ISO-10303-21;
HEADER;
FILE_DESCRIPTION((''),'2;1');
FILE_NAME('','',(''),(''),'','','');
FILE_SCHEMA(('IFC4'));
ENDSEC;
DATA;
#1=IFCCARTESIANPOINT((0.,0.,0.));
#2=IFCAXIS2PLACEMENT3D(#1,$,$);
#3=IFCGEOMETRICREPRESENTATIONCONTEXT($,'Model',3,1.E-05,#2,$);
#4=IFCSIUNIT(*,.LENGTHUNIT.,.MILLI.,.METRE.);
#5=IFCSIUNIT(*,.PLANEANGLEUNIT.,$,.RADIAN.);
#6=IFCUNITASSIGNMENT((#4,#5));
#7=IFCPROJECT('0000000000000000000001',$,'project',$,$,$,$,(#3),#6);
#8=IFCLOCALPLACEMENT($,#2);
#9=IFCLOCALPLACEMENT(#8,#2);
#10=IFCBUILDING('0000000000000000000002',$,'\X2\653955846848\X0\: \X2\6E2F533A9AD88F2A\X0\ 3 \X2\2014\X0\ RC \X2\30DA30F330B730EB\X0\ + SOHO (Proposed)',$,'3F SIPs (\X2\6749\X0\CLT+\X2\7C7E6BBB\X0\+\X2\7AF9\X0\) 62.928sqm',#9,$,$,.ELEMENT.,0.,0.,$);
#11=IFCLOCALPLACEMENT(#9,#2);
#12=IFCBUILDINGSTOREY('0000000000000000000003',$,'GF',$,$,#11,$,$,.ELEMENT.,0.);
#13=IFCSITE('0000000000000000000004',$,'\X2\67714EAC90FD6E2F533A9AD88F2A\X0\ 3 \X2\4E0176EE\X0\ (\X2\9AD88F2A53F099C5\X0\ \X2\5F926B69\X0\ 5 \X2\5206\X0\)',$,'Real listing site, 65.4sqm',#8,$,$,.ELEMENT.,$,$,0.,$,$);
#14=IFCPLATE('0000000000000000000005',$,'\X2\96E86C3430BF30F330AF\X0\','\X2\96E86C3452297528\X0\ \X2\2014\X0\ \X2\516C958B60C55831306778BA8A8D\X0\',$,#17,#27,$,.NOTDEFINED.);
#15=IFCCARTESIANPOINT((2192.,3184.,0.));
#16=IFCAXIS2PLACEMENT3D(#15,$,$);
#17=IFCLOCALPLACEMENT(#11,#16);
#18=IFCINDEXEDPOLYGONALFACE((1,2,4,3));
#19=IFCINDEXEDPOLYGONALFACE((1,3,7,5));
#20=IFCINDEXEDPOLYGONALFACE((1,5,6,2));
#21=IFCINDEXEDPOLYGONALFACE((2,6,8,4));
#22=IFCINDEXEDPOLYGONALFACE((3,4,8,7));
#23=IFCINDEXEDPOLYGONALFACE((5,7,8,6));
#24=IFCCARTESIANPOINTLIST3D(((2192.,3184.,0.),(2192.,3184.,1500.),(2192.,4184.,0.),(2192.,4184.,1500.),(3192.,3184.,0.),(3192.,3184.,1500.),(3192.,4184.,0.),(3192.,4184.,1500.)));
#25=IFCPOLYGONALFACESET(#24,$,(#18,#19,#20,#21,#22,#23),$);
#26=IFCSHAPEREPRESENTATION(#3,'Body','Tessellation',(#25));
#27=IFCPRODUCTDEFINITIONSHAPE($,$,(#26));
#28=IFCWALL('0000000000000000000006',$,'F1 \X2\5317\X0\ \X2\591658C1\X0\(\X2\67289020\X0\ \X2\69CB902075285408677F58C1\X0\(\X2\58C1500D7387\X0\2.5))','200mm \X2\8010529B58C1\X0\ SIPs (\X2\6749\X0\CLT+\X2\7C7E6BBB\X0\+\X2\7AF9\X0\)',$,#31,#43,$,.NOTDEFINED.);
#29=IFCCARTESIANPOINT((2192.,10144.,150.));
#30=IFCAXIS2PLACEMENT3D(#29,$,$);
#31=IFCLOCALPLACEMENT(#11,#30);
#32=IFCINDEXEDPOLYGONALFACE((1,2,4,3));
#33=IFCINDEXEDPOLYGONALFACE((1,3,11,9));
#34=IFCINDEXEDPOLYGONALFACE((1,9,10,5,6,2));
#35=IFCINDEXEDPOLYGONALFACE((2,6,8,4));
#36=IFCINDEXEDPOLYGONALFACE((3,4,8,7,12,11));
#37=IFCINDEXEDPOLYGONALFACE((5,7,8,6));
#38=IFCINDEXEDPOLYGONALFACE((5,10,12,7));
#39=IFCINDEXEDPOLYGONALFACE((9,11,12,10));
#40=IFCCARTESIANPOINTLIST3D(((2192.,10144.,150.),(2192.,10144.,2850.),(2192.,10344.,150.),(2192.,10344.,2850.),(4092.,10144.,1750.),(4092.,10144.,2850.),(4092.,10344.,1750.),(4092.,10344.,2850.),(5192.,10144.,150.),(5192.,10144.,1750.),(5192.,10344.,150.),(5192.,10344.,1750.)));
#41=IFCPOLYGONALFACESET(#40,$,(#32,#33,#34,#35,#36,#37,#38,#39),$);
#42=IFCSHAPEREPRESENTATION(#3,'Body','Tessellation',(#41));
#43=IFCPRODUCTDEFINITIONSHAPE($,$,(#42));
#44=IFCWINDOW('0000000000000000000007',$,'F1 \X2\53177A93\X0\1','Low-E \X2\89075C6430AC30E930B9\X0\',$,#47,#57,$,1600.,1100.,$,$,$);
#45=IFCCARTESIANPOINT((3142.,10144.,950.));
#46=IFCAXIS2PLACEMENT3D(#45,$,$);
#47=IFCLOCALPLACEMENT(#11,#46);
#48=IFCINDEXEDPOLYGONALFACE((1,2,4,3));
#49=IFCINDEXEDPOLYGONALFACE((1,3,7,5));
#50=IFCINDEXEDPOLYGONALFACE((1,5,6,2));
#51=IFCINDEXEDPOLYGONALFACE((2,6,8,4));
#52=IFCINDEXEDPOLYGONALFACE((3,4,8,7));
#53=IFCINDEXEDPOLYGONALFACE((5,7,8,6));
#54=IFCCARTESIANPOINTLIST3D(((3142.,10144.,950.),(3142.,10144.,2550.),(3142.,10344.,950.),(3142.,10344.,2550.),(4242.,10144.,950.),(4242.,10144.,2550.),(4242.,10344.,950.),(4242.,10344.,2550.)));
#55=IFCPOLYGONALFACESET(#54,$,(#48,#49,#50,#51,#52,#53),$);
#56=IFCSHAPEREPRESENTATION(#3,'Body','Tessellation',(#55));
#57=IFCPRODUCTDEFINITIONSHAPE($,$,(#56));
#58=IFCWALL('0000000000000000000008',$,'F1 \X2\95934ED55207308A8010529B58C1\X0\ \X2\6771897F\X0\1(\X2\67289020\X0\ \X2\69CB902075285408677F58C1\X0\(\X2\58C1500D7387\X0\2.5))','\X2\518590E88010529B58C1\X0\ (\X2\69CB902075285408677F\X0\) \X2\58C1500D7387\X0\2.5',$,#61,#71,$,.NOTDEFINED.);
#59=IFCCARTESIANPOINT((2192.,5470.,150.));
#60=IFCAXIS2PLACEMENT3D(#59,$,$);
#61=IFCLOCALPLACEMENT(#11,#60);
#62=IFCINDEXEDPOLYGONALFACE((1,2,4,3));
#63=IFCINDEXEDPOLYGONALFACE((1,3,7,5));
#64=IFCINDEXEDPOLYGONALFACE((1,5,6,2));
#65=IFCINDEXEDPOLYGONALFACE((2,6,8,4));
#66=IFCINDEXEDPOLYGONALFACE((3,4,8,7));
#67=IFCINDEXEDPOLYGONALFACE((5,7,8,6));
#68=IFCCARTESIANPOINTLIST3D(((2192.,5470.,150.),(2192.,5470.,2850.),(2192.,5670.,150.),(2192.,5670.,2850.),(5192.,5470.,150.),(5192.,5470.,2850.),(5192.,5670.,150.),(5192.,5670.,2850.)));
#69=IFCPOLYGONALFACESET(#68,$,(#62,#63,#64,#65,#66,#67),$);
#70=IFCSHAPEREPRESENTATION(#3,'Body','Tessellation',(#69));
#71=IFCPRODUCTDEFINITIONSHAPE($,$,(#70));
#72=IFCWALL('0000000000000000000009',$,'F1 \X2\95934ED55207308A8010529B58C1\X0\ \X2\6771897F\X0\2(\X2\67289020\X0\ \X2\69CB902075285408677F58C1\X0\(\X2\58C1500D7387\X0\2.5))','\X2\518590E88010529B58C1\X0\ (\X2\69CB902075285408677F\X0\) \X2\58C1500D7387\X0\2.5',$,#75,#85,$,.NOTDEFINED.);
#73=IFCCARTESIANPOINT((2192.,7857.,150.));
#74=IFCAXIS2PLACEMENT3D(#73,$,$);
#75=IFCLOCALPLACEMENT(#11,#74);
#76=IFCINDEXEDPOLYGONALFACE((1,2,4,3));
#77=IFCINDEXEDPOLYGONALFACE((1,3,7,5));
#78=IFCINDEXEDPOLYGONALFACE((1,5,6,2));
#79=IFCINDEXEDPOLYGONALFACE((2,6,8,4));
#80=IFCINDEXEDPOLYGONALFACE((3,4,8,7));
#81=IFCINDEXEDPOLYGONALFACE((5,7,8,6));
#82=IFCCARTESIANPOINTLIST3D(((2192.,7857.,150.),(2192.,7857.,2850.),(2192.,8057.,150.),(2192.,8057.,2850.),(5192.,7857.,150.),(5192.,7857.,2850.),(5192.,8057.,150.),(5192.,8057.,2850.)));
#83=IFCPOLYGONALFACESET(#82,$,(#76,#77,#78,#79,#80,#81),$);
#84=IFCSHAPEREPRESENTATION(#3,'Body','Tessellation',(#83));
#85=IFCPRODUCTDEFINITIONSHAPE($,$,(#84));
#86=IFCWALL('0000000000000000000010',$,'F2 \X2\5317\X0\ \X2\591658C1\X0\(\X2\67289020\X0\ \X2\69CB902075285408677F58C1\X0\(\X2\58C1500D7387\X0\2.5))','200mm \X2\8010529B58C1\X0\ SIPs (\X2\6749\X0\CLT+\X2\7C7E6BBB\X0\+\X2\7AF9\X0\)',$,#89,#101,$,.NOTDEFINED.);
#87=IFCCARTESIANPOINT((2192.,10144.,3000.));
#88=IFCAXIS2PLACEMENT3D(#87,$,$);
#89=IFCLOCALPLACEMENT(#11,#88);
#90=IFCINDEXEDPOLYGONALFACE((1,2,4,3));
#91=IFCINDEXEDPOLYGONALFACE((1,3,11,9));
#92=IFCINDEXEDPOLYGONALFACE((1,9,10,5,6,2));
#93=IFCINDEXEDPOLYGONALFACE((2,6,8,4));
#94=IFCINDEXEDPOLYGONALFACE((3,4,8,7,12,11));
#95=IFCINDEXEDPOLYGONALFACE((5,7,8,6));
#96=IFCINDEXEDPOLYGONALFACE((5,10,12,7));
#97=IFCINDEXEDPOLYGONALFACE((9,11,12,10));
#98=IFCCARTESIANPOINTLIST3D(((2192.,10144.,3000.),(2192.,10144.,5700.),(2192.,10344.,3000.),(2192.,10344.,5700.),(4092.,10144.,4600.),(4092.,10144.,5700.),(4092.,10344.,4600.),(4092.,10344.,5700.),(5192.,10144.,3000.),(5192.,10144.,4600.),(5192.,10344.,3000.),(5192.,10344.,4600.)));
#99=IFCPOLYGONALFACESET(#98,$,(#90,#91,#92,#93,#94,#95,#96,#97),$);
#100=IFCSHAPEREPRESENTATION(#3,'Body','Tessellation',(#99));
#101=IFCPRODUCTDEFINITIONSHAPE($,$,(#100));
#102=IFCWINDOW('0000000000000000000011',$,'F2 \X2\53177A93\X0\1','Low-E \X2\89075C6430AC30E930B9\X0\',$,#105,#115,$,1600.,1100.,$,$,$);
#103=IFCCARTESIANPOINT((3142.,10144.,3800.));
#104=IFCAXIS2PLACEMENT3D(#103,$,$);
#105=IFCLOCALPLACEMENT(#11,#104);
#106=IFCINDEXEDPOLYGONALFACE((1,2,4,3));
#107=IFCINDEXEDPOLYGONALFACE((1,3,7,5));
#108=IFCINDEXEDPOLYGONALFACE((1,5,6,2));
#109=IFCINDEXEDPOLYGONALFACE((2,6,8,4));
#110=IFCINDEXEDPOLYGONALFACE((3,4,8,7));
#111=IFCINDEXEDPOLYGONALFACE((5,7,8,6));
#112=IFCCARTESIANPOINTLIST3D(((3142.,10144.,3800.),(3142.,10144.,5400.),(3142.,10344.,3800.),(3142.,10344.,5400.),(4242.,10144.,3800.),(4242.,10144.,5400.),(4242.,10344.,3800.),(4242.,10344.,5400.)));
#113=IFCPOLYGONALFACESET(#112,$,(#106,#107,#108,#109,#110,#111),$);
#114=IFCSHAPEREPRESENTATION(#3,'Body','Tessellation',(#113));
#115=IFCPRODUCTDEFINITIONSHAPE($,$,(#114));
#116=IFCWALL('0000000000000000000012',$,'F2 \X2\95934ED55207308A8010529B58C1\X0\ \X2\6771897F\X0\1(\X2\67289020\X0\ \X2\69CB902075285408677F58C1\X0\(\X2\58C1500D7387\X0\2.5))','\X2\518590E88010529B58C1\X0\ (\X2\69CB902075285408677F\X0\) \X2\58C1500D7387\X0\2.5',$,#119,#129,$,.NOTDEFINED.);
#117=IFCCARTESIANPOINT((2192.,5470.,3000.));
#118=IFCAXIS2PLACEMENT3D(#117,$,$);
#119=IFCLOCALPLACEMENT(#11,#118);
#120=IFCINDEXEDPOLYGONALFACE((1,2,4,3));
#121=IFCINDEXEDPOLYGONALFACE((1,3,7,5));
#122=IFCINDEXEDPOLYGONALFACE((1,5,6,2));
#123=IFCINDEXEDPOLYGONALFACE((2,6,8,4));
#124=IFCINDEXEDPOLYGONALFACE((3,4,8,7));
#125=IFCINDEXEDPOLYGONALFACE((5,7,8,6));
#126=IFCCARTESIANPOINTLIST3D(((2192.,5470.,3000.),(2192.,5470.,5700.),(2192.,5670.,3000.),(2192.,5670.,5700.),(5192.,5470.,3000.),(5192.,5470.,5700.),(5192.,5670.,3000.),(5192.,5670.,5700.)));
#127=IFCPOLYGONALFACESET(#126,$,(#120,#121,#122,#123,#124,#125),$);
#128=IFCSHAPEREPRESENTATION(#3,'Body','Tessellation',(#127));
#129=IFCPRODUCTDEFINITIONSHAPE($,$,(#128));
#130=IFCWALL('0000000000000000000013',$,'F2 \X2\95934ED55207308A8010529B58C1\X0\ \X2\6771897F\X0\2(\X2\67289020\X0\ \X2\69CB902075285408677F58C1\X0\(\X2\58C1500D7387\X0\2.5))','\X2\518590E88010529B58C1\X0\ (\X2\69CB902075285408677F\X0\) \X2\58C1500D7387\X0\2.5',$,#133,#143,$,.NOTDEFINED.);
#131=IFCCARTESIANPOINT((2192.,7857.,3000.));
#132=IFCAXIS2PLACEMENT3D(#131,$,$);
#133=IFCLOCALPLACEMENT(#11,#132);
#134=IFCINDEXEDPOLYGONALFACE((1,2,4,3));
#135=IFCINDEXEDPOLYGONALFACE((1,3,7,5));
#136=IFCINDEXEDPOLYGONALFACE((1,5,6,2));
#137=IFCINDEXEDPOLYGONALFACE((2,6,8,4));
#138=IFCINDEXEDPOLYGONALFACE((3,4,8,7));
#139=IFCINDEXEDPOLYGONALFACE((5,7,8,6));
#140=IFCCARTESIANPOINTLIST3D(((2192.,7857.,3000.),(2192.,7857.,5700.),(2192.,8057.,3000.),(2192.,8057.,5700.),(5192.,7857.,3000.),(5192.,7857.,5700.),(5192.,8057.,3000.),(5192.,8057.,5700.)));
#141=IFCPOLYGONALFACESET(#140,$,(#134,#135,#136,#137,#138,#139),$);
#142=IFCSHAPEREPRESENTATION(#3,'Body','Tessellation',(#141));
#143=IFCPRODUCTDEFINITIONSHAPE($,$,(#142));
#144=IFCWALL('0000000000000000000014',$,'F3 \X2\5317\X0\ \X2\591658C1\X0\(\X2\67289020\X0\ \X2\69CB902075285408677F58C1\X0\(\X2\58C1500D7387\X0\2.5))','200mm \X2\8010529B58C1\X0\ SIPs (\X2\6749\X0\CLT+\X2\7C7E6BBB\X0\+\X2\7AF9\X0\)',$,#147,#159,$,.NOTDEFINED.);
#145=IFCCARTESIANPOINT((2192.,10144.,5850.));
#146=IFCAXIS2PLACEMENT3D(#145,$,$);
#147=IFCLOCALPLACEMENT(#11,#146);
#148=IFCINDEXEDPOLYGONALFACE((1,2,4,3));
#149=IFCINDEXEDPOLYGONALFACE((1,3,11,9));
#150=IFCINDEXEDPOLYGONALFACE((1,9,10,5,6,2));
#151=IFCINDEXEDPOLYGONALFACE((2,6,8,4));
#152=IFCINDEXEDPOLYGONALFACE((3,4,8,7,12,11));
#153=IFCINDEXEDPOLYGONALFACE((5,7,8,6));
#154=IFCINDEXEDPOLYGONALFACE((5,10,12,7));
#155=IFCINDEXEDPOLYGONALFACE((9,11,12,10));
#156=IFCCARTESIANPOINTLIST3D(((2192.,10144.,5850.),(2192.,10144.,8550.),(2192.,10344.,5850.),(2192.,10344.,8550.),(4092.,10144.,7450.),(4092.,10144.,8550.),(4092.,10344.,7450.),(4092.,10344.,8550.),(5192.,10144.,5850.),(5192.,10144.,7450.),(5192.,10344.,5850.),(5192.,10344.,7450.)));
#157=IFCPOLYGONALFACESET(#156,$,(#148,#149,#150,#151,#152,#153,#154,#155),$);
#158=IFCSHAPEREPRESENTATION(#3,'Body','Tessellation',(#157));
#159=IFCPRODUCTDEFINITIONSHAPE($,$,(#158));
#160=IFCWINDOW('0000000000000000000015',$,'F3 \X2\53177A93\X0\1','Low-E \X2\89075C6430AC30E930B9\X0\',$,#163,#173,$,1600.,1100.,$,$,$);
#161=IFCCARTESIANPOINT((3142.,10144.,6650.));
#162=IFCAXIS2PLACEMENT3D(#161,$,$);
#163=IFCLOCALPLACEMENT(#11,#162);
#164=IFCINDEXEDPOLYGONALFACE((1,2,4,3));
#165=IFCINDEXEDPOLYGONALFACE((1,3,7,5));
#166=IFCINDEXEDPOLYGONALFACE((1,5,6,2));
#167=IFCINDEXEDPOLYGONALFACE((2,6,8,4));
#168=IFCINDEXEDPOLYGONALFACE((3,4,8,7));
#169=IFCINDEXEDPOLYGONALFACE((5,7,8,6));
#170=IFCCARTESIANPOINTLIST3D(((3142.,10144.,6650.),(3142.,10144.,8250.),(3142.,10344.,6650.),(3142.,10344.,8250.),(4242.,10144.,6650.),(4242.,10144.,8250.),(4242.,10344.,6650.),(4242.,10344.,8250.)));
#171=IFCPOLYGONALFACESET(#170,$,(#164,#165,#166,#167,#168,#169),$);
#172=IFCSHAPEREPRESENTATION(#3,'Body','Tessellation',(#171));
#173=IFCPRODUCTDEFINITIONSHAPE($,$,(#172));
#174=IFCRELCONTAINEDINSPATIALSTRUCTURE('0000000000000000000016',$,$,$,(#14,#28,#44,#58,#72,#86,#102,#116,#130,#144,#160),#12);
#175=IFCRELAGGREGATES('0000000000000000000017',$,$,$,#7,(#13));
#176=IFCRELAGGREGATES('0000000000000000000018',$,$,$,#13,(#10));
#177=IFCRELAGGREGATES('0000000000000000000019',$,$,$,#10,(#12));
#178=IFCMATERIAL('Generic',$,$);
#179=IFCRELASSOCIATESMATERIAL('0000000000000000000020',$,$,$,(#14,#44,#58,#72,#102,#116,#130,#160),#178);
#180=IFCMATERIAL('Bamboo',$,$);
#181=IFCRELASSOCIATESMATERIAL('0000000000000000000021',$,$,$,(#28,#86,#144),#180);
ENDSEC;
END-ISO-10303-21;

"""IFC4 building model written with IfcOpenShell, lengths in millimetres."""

from ifc_helpers import new_model, si_unit, frame, frame_2d, origin, place, context, project, spatial, rectangle, extrude, material, element, fill, save


model = new_model("IFC4")

# Units and contexts
model_context = context("Model", 3, precision=1e-05, world=origin())
ifc_project = project(units=[si_unit("LENGTHUNIT", "METRE", prefix="MILLI"), si_unit("PLANEANGLEUNIT", "RADIAN")], contexts=[model_context])

# Site, building, storey
site_placement = place(None, origin())
site = spatial("IfcSite", under=ifc_project, at=site_placement, Name="東京都港区高輪 3 丁目 (高輪台駅 徒歩 5 分)", ObjectType="Real listing site, 65.4sqm", CompositionType="ELEMENT", RefElevation=0.0)
building_placement = place(site_placement, origin())
building = spatial("IfcBuilding", under=site, at=building_placement, Name="改善案: 港区高輪 3 — RC ペンシル + SOHO (Proposed)", ObjectType="3F SIPs (杉CLT+籾殻+竹) 62.928sqm", CompositionType="ELEMENT", ElevationOfRefHeight=0.0, ElevationOfTerrain=0.0)
storey_placement = place(building_placement, origin())
storey = spatial("IfcBuildingStorey", under=building, at=storey_placement, Name="GF", CompositionType="ELEMENT", Elevation=0.0)

# Plate
ifc_material_1 = material(Name="Generic")
plate_placement = place(storey_placement, frame((2192.0, 3184.0, 0.0)))
element("IfcPlate", 1, at=plate_placement, inside=storey, material=ifc_material_1, Name="雨水タンク", Description="雨水利用 — 公開情報で確認", PredefinedType="NOTDEFINED", context=model_context, shape_type="SweptSolid", body=[
    extrude(rectangle(XDim=1000.0, YDim=1000.0, at=frame_2d((500.0, 500.0))), frame((2192.0, 3184.0, 0.0)), (0.0, 0.0, 1.0), 1500.0),
])

# Wall, opening, window
ifc_material_2 = material(Name="Bamboo")
wall_1_placement = place(storey_placement, frame((2192.0, 10144.0, 150.0)))
wall_1 = element("IfcWall", 2, at=wall_1_placement, inside=storey, material=ifc_material_2, Name="F1 北 外壁(木造 構造用合板壁(壁倍率2.5))", Description="200mm 耐力壁 SIPs (杉CLT+籾殻+竹)", PredefinedType="NOTDEFINED", context=model_context, shape_type="SweptSolid", body=[
    extrude(rectangle(XDim=3000.0, YDim=200.0, at=frame_2d((1500.0, 100.0))), frame((2192.0, 10144.0, 150.0)), (0.0, 0.0, 1.0), 2700.0),
])
opening_1_placement = place(storey_placement, frame((3142.0, 10144.0, 950.0)))
opening_1 = element("IfcOpeningElement", 3, at=opening_1_placement, cuts=wall_1, PredefinedType="NOTDEFINED", context=model_context, shape_type="SweptSolid", body=[
    extrude(rectangle(XDim=1100.0, YDim=200.0, at=frame_2d((550.0, 100.0))), frame((3142.0, 10144.0, 950.0)), (0.0, 0.0, 1.0), 1600.0),
])
window_1_placement = place(storey_placement, frame((3142.0, 10144.0, 950.0)))
window_1 = element("IfcWindow", 4, at=window_1_placement, inside=storey, material=ifc_material_1, Name="F1 北窓1", Description="Low-E 複層ガラス", OverallHeight=1600.0, OverallWidth=1100.0, context=model_context, shape_type="SweptSolid", body=[
    extrude(rectangle(XDim=1100.0, YDim=200.0, at=frame_2d((550.0, 100.0))), frame((3142.0, 10144.0, 950.0)), (0.0, 0.0, 1.0), 1600.0),
])
fill(opening_1, window_1)

# Walls
wall_2_placement = place(storey_placement, frame((2192.0, 5470.0, 150.0)))
element("IfcWall", 5, at=wall_2_placement, inside=storey, material=ifc_material_1, Name="F1 間仕切り耐力壁 東西1(木造 構造用合板壁(壁倍率2.5))", Description="内部耐力壁 (構造用合板) 壁倍率2.5", PredefinedType="NOTDEFINED", context=model_context, shape_type="SweptSolid", body=[
    extrude(rectangle(XDim=3000.0, YDim=200.0, at=frame_2d((1500.0, 100.0))), frame((2192.0, 5470.0, 150.0)), (0.0, 0.0, 1.0), 2700.0),
])
wall_3_placement = place(storey_placement, frame((2192.0, 7857.0, 150.0)))
element("IfcWall", 6, at=wall_3_placement, inside=storey, material=ifc_material_1, Name="F1 間仕切り耐力壁 東西2(木造 構造用合板壁(壁倍率2.5))", Description="内部耐力壁 (構造用合板) 壁倍率2.5", PredefinedType="NOTDEFINED", context=model_context, shape_type="SweptSolid", body=[
    extrude(rectangle(XDim=3000.0, YDim=200.0, at=frame_2d((1500.0, 100.0))), frame((2192.0, 7857.0, 150.0)), (0.0, 0.0, 1.0), 2700.0),
])

# Wall, opening, window
wall_4_placement = place(storey_placement, frame((2192.0, 10144.0, 3000.0)))
wall_4 = element("IfcWall", 7, at=wall_4_placement, inside=storey, material=ifc_material_2, Name="F2 北 外壁(木造 構造用合板壁(壁倍率2.5))", Description="200mm 耐力壁 SIPs (杉CLT+籾殻+竹)", PredefinedType="NOTDEFINED", context=model_context, shape_type="SweptSolid", body=[
    extrude(rectangle(XDim=3000.0, YDim=200.0, at=frame_2d((1500.0, 100.0))), frame((2192.0, 10144.0, 3000.0)), (0.0, 0.0, 1.0), 2700.0),
])
opening_2_placement = place(storey_placement, frame((3142.0, 10144.0, 3800.0)))
opening_2 = element("IfcOpeningElement", 8, at=opening_2_placement, cuts=wall_4, PredefinedType="NOTDEFINED", context=model_context, shape_type="SweptSolid", body=[
    extrude(rectangle(XDim=1100.0, YDim=200.0, at=frame_2d((550.0, 100.0))), frame((3142.0, 10144.0, 3800.0)), (0.0, 0.0, 1.0), 1600.0),
])
window_2_placement = place(storey_placement, frame((3142.0, 10144.0, 3800.0)))
window_2 = element("IfcWindow", 9, at=window_2_placement, inside=storey, material=ifc_material_1, Name="F2 北窓1", Description="Low-E 複層ガラス", OverallHeight=1600.0, OverallWidth=1100.0, context=model_context, shape_type="SweptSolid", body=[
    extrude(rectangle(XDim=1100.0, YDim=200.0, at=frame_2d((550.0, 100.0))), frame((3142.0, 10144.0, 3800.0)), (0.0, 0.0, 1.0), 1600.0),
])
fill(opening_2, window_2)

# Walls
wall_5_placement = place(storey_placement, frame((2192.0, 5470.0, 3000.0)))
element("IfcWall", 10, at=wall_5_placement, inside=storey, material=ifc_material_1, Name="F2 間仕切り耐力壁 東西1(木造 構造用合板壁(壁倍率2.5))", Description="内部耐力壁 (構造用合板) 壁倍率2.5", PredefinedType="NOTDEFINED", context=model_context, shape_type="SweptSolid", body=[
    extrude(rectangle(XDim=3000.0, YDim=200.0, at=frame_2d((1500.0, 100.0))), frame((2192.0, 5470.0, 3000.0)), (0.0, 0.0, 1.0), 2700.0),
])
wall_6_placement = place(storey_placement, frame((2192.0, 7857.0, 3000.0)))
element("IfcWall", 11, at=wall_6_placement, inside=storey, material=ifc_material_1, Name="F2 間仕切り耐力壁 東西2(木造 構造用合板壁(壁倍率2.5))", Description="内部耐力壁 (構造用合板) 壁倍率2.5", PredefinedType="NOTDEFINED", context=model_context, shape_type="SweptSolid", body=[
    extrude(rectangle(XDim=3000.0, YDim=200.0, at=frame_2d((1500.0, 100.0))), frame((2192.0, 7857.0, 3000.0)), (0.0, 0.0, 1.0), 2700.0),
])

# Wall, opening, window
wall_7_placement = place(storey_placement, frame((2192.0, 10144.0, 5850.0)))
wall_7 = element("IfcWall", 12, at=wall_7_placement, inside=storey, material=ifc_material_2, Name="F3 北 外壁(木造 構造用合板壁(壁倍率2.5))", Description="200mm 耐力壁 SIPs (杉CLT+籾殻+竹)", PredefinedType="NOTDEFINED", context=model_context, shape_type="SweptSolid", body=[
    extrude(rectangle(XDim=3000.0, YDim=200.0, at=frame_2d((1500.0, 100.0))), frame((2192.0, 10144.0, 5850.0)), (0.0, 0.0, 1.0), 2700.0),
])
opening_3_placement = place(storey_placement, frame((3142.0, 10144.0, 6650.0)))
opening_3 = element("IfcOpeningElement", 13, at=opening_3_placement, cuts=wall_7, PredefinedType="NOTDEFINED", context=model_context, shape_type="SweptSolid", body=[
    extrude(rectangle(XDim=1100.0, YDim=200.0, at=frame_2d((550.0, 100.0))), frame((3142.0, 10144.0, 6650.0)), (0.0, 0.0, 1.0), 1600.0),
])
window_3_placement = place(storey_placement, frame((3142.0, 10144.0, 6650.0)))
window_3 = element("IfcWindow", 14, at=window_3_placement, inside=storey, material=ifc_material_1, Name="F3 北窓1", Description="Low-E 複層ガラス", OverallHeight=1600.0, OverallWidth=1100.0, context=model_context, shape_type="SweptSolid", body=[
    extrude(rectangle(XDim=1100.0, YDim=200.0, at=frame_2d((550.0, 100.0))), frame((3142.0, 10144.0, 6650.0)), (0.0, 0.0, 1.0), 1600.0),
])
fill(opening_3, window_3)

save(model, "model.ifc")
